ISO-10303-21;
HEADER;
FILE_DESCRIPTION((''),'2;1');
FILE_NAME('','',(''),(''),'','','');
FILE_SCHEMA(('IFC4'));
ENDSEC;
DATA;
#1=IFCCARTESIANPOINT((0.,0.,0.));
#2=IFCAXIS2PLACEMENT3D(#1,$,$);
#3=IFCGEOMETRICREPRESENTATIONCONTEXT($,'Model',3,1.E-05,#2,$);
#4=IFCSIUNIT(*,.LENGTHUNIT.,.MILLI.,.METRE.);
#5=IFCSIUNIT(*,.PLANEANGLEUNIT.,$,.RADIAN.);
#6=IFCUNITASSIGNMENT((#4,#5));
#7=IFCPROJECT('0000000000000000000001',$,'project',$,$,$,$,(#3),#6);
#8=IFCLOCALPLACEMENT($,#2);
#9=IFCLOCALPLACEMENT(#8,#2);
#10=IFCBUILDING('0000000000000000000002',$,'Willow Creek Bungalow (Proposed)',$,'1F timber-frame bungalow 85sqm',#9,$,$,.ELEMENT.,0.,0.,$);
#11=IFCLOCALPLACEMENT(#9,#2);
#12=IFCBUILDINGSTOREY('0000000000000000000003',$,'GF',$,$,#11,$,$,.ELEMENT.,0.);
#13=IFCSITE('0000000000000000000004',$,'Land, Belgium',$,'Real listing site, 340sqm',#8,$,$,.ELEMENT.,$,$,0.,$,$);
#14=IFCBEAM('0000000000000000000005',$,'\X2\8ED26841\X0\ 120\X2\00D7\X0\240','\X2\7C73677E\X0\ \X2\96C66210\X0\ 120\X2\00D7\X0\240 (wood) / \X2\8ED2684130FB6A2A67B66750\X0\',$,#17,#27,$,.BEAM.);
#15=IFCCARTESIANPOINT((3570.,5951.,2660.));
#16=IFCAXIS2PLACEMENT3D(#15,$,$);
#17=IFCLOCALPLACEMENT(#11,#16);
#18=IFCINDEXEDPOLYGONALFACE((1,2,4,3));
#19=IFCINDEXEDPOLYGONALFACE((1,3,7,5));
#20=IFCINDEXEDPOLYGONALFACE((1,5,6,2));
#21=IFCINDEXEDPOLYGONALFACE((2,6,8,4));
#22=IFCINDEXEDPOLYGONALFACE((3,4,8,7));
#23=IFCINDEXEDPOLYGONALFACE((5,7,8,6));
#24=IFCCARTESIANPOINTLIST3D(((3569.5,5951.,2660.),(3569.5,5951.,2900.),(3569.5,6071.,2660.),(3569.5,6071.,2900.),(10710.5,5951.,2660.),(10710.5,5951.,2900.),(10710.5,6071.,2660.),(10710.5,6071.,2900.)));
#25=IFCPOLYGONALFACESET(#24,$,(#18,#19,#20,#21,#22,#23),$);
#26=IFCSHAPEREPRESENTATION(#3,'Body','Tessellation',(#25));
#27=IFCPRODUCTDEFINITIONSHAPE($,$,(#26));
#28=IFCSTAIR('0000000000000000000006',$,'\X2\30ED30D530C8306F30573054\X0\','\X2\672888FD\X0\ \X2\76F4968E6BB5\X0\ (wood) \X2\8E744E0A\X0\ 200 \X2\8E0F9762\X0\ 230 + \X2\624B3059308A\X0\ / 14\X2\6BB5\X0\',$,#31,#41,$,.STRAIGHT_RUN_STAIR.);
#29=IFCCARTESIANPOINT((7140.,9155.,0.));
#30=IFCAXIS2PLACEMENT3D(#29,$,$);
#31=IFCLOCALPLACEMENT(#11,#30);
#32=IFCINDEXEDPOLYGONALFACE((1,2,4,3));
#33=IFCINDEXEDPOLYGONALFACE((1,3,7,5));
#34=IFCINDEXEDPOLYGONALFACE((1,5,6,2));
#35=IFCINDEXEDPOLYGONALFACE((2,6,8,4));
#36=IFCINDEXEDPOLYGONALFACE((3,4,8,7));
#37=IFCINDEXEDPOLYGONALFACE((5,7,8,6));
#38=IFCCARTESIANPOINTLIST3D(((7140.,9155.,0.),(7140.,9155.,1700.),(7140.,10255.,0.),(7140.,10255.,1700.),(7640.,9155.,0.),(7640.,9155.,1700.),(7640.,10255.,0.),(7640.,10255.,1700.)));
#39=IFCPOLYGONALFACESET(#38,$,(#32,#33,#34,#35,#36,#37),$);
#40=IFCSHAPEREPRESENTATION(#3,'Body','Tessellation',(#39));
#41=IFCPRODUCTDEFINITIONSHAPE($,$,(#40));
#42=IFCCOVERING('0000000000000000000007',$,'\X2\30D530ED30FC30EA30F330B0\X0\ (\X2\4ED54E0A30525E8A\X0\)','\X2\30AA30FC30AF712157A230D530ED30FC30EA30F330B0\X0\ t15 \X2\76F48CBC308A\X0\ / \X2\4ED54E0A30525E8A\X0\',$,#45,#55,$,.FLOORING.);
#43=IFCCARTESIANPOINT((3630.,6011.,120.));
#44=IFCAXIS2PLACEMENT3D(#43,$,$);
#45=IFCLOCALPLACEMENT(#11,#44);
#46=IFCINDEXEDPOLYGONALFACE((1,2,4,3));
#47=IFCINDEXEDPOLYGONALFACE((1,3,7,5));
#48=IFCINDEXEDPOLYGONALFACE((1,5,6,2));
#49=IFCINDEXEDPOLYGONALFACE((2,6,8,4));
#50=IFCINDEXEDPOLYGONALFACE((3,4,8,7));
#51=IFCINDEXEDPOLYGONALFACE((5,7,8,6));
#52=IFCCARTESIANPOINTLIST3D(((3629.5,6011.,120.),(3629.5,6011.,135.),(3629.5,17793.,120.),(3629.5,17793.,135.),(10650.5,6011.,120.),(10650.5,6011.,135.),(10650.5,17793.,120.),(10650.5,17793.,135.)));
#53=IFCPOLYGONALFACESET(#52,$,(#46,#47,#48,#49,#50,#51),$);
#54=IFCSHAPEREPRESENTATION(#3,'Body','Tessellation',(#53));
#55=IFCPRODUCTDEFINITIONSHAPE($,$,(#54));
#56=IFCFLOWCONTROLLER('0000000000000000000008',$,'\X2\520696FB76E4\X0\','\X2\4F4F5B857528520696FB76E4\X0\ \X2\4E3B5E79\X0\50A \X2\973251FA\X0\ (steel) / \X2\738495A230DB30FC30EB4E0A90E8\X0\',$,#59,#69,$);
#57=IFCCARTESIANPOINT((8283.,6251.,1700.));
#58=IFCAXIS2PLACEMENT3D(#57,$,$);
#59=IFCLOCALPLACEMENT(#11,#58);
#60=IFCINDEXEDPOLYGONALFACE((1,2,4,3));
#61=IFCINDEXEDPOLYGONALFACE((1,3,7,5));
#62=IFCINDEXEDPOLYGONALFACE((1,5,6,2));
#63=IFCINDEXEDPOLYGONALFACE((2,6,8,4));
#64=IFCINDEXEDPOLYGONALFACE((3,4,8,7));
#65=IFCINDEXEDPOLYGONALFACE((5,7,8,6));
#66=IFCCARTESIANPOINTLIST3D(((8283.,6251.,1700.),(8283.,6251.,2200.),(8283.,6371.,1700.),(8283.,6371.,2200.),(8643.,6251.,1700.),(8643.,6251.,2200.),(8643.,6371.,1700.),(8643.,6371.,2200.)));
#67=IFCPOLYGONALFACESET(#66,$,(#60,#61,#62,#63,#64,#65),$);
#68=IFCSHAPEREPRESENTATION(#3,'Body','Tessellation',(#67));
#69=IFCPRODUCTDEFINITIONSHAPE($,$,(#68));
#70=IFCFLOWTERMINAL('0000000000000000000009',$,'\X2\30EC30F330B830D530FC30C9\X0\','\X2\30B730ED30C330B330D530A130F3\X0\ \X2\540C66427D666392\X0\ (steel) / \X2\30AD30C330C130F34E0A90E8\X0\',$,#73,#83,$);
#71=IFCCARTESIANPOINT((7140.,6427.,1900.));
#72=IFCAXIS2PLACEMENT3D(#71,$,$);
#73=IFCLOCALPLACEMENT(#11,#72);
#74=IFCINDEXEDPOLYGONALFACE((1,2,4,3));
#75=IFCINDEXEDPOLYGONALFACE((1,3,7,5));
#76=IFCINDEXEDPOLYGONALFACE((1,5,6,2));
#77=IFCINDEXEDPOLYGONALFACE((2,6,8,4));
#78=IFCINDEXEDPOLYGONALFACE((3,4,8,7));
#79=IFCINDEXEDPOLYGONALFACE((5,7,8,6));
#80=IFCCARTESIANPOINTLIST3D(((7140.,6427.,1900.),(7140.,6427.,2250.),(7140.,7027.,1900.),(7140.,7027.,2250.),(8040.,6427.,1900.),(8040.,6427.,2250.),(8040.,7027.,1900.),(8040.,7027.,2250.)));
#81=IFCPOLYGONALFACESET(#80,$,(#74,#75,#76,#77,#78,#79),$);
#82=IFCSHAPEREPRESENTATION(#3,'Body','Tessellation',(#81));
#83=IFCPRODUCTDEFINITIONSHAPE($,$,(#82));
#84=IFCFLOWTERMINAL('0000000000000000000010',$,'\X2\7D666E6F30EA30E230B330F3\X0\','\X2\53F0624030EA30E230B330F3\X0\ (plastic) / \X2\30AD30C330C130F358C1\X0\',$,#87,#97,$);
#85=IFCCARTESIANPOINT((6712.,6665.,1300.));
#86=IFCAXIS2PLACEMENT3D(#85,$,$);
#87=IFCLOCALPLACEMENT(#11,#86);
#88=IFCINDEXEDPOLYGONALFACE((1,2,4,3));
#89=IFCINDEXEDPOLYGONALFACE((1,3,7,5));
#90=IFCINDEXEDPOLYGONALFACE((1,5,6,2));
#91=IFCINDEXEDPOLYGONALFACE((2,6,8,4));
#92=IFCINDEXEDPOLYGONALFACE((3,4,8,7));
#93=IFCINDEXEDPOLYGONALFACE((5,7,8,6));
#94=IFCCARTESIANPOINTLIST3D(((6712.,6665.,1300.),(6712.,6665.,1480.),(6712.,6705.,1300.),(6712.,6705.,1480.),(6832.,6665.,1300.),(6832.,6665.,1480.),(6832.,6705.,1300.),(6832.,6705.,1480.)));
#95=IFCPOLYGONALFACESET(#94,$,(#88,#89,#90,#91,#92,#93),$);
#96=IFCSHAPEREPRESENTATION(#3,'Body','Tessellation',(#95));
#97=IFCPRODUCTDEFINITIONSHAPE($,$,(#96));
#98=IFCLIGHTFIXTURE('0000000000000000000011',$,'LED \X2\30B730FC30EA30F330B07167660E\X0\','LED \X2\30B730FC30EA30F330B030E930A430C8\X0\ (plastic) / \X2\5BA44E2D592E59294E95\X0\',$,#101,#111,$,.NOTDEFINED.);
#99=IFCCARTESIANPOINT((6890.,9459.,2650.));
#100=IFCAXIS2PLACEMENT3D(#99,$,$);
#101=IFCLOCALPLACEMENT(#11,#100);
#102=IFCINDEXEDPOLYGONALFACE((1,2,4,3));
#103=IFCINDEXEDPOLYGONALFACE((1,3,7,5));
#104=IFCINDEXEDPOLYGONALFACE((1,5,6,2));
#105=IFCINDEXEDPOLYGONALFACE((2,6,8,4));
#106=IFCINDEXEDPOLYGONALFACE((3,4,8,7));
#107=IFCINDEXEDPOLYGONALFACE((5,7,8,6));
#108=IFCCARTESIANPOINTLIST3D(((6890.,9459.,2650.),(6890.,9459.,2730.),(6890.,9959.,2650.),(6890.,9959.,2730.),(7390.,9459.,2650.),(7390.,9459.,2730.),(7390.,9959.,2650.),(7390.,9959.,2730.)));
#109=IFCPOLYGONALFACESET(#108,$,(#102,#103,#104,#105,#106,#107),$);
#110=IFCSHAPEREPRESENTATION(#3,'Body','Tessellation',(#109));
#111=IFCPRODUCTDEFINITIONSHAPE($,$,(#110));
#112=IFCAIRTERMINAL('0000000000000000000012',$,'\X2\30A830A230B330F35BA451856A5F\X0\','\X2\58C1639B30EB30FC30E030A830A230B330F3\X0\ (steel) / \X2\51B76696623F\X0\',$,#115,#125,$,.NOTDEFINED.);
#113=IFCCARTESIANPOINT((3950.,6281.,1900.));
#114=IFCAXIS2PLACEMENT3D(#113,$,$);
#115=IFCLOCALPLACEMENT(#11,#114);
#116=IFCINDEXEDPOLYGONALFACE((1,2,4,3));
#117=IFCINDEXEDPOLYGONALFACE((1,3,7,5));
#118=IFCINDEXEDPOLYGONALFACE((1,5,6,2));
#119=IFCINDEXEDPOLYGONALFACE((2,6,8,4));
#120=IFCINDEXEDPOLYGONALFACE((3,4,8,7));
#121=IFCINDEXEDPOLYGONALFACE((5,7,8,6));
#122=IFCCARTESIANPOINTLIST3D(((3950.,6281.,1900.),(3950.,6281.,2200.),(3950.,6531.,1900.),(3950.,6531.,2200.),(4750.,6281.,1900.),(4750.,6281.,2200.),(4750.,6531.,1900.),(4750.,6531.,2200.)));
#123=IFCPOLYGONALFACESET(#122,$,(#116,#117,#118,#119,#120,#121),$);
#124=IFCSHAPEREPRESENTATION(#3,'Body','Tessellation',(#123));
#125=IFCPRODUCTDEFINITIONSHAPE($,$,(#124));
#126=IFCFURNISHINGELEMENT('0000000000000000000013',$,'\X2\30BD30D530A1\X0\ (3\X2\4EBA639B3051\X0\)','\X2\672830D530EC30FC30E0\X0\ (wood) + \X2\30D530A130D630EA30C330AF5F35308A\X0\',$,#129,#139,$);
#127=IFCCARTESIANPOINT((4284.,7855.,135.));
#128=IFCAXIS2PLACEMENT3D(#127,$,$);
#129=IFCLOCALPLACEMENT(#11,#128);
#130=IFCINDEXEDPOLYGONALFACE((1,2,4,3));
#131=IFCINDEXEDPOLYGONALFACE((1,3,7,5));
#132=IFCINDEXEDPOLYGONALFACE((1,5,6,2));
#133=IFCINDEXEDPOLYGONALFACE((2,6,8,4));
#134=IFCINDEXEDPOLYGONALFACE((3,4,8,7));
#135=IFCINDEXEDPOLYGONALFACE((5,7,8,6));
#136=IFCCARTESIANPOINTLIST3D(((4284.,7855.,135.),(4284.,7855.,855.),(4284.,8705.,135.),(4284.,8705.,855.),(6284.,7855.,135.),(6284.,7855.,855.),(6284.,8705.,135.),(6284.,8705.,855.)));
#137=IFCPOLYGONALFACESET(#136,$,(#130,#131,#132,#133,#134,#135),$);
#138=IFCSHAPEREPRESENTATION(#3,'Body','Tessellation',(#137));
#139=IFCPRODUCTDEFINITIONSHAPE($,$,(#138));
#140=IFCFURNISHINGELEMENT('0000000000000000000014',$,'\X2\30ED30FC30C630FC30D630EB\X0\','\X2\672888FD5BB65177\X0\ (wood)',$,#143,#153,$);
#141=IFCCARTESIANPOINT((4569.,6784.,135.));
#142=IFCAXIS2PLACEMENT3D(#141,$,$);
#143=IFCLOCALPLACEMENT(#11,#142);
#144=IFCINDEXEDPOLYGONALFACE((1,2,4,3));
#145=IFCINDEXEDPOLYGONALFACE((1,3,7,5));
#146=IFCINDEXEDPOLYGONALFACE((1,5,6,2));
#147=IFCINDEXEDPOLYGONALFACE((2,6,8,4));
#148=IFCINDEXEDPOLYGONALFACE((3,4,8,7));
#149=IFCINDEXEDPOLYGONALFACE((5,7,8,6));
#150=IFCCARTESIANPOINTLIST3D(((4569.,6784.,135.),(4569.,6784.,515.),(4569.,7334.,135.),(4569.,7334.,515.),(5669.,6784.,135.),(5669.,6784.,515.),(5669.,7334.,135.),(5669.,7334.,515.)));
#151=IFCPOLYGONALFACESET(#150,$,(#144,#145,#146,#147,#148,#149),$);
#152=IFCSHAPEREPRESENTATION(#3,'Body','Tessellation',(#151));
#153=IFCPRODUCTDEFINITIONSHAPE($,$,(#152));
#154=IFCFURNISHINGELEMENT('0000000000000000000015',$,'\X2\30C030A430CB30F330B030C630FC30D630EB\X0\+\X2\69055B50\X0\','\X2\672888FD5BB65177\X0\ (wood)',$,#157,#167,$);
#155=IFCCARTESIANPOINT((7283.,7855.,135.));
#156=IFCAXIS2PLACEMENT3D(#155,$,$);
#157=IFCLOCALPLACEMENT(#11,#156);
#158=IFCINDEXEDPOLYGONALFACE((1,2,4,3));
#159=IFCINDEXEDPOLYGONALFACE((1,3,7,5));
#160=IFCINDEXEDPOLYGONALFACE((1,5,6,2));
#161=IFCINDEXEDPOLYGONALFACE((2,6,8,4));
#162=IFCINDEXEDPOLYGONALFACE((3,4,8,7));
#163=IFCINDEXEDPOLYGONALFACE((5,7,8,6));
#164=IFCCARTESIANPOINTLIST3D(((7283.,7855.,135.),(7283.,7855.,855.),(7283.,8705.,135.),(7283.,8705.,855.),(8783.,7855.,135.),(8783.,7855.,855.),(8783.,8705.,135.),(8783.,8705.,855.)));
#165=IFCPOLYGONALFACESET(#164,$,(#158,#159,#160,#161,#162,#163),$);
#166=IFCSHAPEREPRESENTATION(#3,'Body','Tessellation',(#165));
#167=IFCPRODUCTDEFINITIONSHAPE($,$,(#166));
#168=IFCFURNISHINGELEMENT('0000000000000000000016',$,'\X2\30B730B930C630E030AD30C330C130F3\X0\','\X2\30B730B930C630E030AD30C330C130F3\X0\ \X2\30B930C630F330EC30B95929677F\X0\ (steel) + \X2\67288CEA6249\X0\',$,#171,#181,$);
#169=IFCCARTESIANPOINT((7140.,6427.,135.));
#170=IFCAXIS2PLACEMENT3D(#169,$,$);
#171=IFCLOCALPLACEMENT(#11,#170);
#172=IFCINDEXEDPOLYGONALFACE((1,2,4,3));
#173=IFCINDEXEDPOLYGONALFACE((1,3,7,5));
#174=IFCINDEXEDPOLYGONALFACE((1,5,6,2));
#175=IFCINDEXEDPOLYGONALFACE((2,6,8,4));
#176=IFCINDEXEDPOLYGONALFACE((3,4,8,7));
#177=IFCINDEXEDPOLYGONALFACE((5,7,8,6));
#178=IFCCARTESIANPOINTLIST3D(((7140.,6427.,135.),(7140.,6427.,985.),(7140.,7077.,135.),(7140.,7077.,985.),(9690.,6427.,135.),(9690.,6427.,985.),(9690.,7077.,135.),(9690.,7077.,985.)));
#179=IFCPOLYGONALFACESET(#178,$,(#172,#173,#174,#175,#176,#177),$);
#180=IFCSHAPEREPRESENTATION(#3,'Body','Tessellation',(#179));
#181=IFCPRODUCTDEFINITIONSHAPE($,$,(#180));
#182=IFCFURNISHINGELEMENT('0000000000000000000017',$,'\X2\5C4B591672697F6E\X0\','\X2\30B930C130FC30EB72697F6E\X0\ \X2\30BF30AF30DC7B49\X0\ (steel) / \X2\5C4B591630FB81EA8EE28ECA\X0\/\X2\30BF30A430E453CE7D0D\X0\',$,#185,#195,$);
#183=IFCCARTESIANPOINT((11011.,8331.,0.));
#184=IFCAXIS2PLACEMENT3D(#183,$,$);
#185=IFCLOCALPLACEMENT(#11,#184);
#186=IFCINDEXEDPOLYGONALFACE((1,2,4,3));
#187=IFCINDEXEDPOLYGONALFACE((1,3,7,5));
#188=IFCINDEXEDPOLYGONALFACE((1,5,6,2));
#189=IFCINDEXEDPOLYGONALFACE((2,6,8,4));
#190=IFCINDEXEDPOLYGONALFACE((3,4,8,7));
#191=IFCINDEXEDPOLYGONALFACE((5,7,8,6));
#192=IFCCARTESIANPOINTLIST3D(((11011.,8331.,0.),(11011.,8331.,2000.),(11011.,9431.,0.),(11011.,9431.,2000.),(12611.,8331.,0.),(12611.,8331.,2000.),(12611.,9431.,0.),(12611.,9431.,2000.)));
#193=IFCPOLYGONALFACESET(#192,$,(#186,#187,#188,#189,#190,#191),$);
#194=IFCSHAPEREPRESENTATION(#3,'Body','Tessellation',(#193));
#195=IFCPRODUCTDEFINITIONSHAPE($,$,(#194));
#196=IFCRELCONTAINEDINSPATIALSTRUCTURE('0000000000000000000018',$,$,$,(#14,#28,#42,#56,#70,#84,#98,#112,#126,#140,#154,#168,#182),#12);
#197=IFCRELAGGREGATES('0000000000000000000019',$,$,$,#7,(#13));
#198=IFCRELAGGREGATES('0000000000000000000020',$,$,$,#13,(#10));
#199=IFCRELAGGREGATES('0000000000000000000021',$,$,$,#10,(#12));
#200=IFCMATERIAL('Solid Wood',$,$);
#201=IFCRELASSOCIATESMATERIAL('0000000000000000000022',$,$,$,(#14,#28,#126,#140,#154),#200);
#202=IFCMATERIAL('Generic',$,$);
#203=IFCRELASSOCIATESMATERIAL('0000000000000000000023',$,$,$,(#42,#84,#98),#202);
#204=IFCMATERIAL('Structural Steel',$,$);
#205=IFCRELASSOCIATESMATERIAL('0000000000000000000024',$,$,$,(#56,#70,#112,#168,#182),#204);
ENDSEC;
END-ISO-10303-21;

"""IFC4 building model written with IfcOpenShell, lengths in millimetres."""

from ifc_helpers import new_model, si_unit, frame, frame_2d, origin, place, context, project, spatial, rectangle, extrude, material, element, save


model = new_model("IFC4")

# Units and contexts
model_context = context("Model", 3, precision=1e-05, world=origin())
ifc_project = project(units=[si_unit("LENGTHUNIT", "METRE", prefix="MILLI"), si_unit("PLANEANGLEUNIT", "RADIAN")], contexts=[model_context])

# Site, building, storey
site_placement = place(None, origin())
site = spatial("IfcSite", under=ifc_project, at=site_placement, Name="Land, Belgium", ObjectType="Real listing site, 340sqm", CompositionType="ELEMENT", RefElevation=0.0)
building_placement = place(site_placement, origin())
building = spatial("IfcBuilding", under=site, at=building_placement, Name="Willow Creek Bungalow (Proposed)", ObjectType="1F timber-frame bungalow 85sqm", CompositionType="ELEMENT", ElevationOfRefHeight=0.0, ElevationOfTerrain=0.0)
storey_placement = place(building_placement, origin())
storey = spatial("IfcBuildingStorey", under=building, at=storey_placement, Name="GF", CompositionType="ELEMENT", Elevation=0.0)

# Shared definitions
ifc_material_1 = material(Name="Solid Wood")

# Beam
beam_1_placement = place(storey_placement, frame((3570.0, 5951.0, 2660.0)))
element("IfcBeam", 1, at=beam_1_placement, inside=storey, material=ifc_material_1, Name="軒桁 120×240", Description="米松 集成 120×240 (wood) / 軒桁・横架材", PredefinedType="BEAM", context=model_context, shape_type="SweptSolid", body=[
    extrude(rectangle(XDim=7141.0, YDim=120.0, at=frame_2d((3570.0, 60.0))), frame((3570.0, 5951.0, 2660.0)), (0.0, 0.0, 1.0), 240.0),
])

# Stair
stair_placement = place(storey_placement, frame((7140.0, 9155.0, 0.0)))
element("IfcStair", 2, at=stair_placement, inside=storey, material=ifc_material_1, Name="ロフトはしご", Description="木製 直階段 (wood) 蹴上 200 踏面 230 + 手すり / 14段", PredefinedType="STRAIGHT_RUN_STAIR", context=model_context, shape_type="SweptSolid", body=[
    extrude(rectangle(XDim=500.0, YDim=1100.0, at=frame_2d((250.0, 550.0))), frame((7140.0, 9155.0, 0.0)), (0.0, 0.0, 1.0), 1700.0),
])

# Covering
ifc_material_2 = material(Name="Generic")
covering_placement = place(storey_placement, frame((3630.0, 6011.0, 120.0)))
element("IfcCovering", 3, at=covering_placement, inside=storey, material=ifc_material_2, Name="フローリング (仕上げ床)", Description="オーク無垢フローリング t15 直貼り / 仕上げ床", PredefinedType="FLOORING", context=model_context, shape_type="SweptSolid", body=[
    extrude(rectangle(XDim=7021.0, YDim=11782.0, at=frame_2d((3510.0, 5891.0))), frame((3630.0, 6011.0, 120.0)), (0.0, 0.0, 1.0), 15.0),
])

# Flow controller
ifc_material_3 = material(Name="Structural Steel")
flow_controller_placement = place(storey_placement, frame((8283.0, 6251.0, 1700.0)))
element("IfcFlowController", 4, at=flow_controller_placement, inside=storey, material=ifc_material_3, Name="分電盤", Description="住宅用分電盤 主幹50A 露出 (steel) / 玄関ホール上部", context=model_context, shape_type="SweptSolid", body=[
    extrude(rectangle(XDim=360.0, YDim=120.0, at=frame_2d((180.0, 60.0))), frame((8283.0, 6251.0, 1700.0)), (0.0, 0.0, 1.0), 500.0),
])

# Flow terminals
flow_terminal_1_placement = place(storey_placement, frame((7140.0, 6427.0, 1900.0)))
element("IfcFlowTerminal", 5, at=flow_terminal_1_placement, inside=storey, material=ifc_material_3, Name="レンジフード", Description="シロッコファン 同時給排 (steel) / キッチン上部", context=model_context, shape_type="SweptSolid", body=[
    extrude(rectangle(XDim=900.0, YDim=600.0, at=frame_2d((450.0, 300.0))), frame((7140.0, 6427.0, 1900.0)), (0.0, 0.0, 1.0), 350.0),
])
flow_terminal_2_placement = place(storey_placement, frame((6712.0, 6665.0, 1300.0)))
element("IfcFlowTerminal", 6, at=flow_terminal_2_placement, inside=storey, material=ifc_material_2, Name="給湯リモコン", Description="台所リモコン (plastic) / キッチン壁", context=model_context, shape_type="SweptSolid", body=[
    extrude(rectangle(XDim=120.0, YDim=40.0, at=frame_2d((60.0, 20.0))), frame((6712.0, 6665.0, 1300.0)), (0.0, 0.0, 1.0), 180.0),
])

# Light fixture
light_fixture_placement = place(storey_placement, frame((6890.0, 9459.0, 2650.0)))
element("IfcLightFixture", 7, at=light_fixture_placement, inside=storey, material=ifc_material_2, Name="LED シーリング照明", Description="LED シーリングライト (plastic) / 室中央天井", PredefinedType="NOTDEFINED", context=model_context, shape_type="SweptSolid", body=[
    extrude(rectangle(XDim=500.0, YDim=500.0, at=frame_2d((250.0, 250.0))), frame((6890.0, 9459.0, 2650.0)), (0.0, 0.0, 1.0), 80.0),
])

# Air terminal
air_terminal_placement = place(storey_placement, frame((3950.0, 6281.0, 1900.0)))
element("IfcAirTerminal", 8, at=air_terminal_placement, inside=storey, material=ifc_material_3, Name="エアコン室内機", Description="壁掛ルームエアコン (steel) / 冷暖房", PredefinedType="NOTDEFINED", context=model_context, shape_type="SweptSolid", body=[
    extrude(rectangle(XDim=800.0, YDim=250.0, at=frame_2d((400.0, 125.0))), frame((3950.0, 6281.0, 1900.0)), (0.0, 0.0, 1.0), 300.0),
])

# Furnishing elements
furnishing_1_placement = place(storey_placement, frame((4284.0, 7855.0, 135.0)))
element("IfcFurnishingElement", 9, at=furnishing_1_placement, inside=storey, material=ifc_material_1, Name="ソファ (3人掛け)", Description="木フレーム (wood) + ファブリック張り", context=model_context, shape_type="SweptSolid", body=[
    extrude(rectangle(XDim=2000.0, YDim=850.0, at=frame_2d((1000.0, 425.0))), frame((4284.0, 7855.0, 135.0)), (0.0, 0.0, 1.0), 720.0),
])
furnishing_2_placement = place(storey_placement, frame((4569.0, 6784.0, 135.0)))
element("IfcFurnishingElement", 10, at=furnishing_2_placement, inside=storey, material=ifc_material_1, Name="ローテーブル", Description="木製家具 (wood)", context=model_context, shape_type="SweptSolid", body=[
    extrude(rectangle(XDim=1100.0, YDim=550.0, at=frame_2d((550.0, 275.0))), frame((4569.0, 6784.0, 135.0)), (0.0, 0.0, 1.0), 380.0),
])
furnishing_3_placement = place(storey_placement, frame((7283.0, 7855.0, 135.0)))
element("IfcFurnishingElement", 11, at=furnishing_3_placement, inside=storey, material=ifc_material_1, Name="ダイニングテーブル+椅子", Description="木製家具 (wood)", context=model_context, shape_type="SweptSolid", body=[
    extrude(rectangle(XDim=1500.0, YDim=850.0, at=frame_2d((750.0, 425.0))), frame((7283.0, 7855.0, 135.0)), (0.0, 0.0, 1.0), 720.0),
])
furnishing_4_placement = place(storey_placement, frame((7140.0, 6427.0, 135.0)))
element("IfcFurnishingElement", 12, at=furnishing_4_placement, inside=storey, material=ifc_material_3, Name="システムキッチン", Description="システムキッチン ステンレス天板 (steel) + 木質扉", context=model_context, shape_type="SweptSolid", body=[
    extrude(rectangle(XDim=2550.0, YDim=650.0, at=frame_2d((1275.0, 325.0))), frame((7140.0, 6427.0, 135.0)), (0.0, 0.0, 1.0), 850.0),
])
furnishing_5_placement = place(storey_placement, frame((11011.0, 8331.0, 0.0)))
element("IfcFurnishingElement", 13, at=furnishing_5_placement, inside=storey, material=ifc_material_3, Name="屋外物置", Description="スチール物置 タクボ等 (steel) / 屋外・自転車/タイヤ収納", context=model_context, shape_type="SweptSolid", body=[
    extrude(rectangle(XDim=1600.0, YDim=1100.0, at=frame_2d((800.0, 550.0))), frame((11011.0, 8331.0, 0.0)), (0.0, 0.0, 1.0), 2000.0),
])

save(model, "model.ifc")
